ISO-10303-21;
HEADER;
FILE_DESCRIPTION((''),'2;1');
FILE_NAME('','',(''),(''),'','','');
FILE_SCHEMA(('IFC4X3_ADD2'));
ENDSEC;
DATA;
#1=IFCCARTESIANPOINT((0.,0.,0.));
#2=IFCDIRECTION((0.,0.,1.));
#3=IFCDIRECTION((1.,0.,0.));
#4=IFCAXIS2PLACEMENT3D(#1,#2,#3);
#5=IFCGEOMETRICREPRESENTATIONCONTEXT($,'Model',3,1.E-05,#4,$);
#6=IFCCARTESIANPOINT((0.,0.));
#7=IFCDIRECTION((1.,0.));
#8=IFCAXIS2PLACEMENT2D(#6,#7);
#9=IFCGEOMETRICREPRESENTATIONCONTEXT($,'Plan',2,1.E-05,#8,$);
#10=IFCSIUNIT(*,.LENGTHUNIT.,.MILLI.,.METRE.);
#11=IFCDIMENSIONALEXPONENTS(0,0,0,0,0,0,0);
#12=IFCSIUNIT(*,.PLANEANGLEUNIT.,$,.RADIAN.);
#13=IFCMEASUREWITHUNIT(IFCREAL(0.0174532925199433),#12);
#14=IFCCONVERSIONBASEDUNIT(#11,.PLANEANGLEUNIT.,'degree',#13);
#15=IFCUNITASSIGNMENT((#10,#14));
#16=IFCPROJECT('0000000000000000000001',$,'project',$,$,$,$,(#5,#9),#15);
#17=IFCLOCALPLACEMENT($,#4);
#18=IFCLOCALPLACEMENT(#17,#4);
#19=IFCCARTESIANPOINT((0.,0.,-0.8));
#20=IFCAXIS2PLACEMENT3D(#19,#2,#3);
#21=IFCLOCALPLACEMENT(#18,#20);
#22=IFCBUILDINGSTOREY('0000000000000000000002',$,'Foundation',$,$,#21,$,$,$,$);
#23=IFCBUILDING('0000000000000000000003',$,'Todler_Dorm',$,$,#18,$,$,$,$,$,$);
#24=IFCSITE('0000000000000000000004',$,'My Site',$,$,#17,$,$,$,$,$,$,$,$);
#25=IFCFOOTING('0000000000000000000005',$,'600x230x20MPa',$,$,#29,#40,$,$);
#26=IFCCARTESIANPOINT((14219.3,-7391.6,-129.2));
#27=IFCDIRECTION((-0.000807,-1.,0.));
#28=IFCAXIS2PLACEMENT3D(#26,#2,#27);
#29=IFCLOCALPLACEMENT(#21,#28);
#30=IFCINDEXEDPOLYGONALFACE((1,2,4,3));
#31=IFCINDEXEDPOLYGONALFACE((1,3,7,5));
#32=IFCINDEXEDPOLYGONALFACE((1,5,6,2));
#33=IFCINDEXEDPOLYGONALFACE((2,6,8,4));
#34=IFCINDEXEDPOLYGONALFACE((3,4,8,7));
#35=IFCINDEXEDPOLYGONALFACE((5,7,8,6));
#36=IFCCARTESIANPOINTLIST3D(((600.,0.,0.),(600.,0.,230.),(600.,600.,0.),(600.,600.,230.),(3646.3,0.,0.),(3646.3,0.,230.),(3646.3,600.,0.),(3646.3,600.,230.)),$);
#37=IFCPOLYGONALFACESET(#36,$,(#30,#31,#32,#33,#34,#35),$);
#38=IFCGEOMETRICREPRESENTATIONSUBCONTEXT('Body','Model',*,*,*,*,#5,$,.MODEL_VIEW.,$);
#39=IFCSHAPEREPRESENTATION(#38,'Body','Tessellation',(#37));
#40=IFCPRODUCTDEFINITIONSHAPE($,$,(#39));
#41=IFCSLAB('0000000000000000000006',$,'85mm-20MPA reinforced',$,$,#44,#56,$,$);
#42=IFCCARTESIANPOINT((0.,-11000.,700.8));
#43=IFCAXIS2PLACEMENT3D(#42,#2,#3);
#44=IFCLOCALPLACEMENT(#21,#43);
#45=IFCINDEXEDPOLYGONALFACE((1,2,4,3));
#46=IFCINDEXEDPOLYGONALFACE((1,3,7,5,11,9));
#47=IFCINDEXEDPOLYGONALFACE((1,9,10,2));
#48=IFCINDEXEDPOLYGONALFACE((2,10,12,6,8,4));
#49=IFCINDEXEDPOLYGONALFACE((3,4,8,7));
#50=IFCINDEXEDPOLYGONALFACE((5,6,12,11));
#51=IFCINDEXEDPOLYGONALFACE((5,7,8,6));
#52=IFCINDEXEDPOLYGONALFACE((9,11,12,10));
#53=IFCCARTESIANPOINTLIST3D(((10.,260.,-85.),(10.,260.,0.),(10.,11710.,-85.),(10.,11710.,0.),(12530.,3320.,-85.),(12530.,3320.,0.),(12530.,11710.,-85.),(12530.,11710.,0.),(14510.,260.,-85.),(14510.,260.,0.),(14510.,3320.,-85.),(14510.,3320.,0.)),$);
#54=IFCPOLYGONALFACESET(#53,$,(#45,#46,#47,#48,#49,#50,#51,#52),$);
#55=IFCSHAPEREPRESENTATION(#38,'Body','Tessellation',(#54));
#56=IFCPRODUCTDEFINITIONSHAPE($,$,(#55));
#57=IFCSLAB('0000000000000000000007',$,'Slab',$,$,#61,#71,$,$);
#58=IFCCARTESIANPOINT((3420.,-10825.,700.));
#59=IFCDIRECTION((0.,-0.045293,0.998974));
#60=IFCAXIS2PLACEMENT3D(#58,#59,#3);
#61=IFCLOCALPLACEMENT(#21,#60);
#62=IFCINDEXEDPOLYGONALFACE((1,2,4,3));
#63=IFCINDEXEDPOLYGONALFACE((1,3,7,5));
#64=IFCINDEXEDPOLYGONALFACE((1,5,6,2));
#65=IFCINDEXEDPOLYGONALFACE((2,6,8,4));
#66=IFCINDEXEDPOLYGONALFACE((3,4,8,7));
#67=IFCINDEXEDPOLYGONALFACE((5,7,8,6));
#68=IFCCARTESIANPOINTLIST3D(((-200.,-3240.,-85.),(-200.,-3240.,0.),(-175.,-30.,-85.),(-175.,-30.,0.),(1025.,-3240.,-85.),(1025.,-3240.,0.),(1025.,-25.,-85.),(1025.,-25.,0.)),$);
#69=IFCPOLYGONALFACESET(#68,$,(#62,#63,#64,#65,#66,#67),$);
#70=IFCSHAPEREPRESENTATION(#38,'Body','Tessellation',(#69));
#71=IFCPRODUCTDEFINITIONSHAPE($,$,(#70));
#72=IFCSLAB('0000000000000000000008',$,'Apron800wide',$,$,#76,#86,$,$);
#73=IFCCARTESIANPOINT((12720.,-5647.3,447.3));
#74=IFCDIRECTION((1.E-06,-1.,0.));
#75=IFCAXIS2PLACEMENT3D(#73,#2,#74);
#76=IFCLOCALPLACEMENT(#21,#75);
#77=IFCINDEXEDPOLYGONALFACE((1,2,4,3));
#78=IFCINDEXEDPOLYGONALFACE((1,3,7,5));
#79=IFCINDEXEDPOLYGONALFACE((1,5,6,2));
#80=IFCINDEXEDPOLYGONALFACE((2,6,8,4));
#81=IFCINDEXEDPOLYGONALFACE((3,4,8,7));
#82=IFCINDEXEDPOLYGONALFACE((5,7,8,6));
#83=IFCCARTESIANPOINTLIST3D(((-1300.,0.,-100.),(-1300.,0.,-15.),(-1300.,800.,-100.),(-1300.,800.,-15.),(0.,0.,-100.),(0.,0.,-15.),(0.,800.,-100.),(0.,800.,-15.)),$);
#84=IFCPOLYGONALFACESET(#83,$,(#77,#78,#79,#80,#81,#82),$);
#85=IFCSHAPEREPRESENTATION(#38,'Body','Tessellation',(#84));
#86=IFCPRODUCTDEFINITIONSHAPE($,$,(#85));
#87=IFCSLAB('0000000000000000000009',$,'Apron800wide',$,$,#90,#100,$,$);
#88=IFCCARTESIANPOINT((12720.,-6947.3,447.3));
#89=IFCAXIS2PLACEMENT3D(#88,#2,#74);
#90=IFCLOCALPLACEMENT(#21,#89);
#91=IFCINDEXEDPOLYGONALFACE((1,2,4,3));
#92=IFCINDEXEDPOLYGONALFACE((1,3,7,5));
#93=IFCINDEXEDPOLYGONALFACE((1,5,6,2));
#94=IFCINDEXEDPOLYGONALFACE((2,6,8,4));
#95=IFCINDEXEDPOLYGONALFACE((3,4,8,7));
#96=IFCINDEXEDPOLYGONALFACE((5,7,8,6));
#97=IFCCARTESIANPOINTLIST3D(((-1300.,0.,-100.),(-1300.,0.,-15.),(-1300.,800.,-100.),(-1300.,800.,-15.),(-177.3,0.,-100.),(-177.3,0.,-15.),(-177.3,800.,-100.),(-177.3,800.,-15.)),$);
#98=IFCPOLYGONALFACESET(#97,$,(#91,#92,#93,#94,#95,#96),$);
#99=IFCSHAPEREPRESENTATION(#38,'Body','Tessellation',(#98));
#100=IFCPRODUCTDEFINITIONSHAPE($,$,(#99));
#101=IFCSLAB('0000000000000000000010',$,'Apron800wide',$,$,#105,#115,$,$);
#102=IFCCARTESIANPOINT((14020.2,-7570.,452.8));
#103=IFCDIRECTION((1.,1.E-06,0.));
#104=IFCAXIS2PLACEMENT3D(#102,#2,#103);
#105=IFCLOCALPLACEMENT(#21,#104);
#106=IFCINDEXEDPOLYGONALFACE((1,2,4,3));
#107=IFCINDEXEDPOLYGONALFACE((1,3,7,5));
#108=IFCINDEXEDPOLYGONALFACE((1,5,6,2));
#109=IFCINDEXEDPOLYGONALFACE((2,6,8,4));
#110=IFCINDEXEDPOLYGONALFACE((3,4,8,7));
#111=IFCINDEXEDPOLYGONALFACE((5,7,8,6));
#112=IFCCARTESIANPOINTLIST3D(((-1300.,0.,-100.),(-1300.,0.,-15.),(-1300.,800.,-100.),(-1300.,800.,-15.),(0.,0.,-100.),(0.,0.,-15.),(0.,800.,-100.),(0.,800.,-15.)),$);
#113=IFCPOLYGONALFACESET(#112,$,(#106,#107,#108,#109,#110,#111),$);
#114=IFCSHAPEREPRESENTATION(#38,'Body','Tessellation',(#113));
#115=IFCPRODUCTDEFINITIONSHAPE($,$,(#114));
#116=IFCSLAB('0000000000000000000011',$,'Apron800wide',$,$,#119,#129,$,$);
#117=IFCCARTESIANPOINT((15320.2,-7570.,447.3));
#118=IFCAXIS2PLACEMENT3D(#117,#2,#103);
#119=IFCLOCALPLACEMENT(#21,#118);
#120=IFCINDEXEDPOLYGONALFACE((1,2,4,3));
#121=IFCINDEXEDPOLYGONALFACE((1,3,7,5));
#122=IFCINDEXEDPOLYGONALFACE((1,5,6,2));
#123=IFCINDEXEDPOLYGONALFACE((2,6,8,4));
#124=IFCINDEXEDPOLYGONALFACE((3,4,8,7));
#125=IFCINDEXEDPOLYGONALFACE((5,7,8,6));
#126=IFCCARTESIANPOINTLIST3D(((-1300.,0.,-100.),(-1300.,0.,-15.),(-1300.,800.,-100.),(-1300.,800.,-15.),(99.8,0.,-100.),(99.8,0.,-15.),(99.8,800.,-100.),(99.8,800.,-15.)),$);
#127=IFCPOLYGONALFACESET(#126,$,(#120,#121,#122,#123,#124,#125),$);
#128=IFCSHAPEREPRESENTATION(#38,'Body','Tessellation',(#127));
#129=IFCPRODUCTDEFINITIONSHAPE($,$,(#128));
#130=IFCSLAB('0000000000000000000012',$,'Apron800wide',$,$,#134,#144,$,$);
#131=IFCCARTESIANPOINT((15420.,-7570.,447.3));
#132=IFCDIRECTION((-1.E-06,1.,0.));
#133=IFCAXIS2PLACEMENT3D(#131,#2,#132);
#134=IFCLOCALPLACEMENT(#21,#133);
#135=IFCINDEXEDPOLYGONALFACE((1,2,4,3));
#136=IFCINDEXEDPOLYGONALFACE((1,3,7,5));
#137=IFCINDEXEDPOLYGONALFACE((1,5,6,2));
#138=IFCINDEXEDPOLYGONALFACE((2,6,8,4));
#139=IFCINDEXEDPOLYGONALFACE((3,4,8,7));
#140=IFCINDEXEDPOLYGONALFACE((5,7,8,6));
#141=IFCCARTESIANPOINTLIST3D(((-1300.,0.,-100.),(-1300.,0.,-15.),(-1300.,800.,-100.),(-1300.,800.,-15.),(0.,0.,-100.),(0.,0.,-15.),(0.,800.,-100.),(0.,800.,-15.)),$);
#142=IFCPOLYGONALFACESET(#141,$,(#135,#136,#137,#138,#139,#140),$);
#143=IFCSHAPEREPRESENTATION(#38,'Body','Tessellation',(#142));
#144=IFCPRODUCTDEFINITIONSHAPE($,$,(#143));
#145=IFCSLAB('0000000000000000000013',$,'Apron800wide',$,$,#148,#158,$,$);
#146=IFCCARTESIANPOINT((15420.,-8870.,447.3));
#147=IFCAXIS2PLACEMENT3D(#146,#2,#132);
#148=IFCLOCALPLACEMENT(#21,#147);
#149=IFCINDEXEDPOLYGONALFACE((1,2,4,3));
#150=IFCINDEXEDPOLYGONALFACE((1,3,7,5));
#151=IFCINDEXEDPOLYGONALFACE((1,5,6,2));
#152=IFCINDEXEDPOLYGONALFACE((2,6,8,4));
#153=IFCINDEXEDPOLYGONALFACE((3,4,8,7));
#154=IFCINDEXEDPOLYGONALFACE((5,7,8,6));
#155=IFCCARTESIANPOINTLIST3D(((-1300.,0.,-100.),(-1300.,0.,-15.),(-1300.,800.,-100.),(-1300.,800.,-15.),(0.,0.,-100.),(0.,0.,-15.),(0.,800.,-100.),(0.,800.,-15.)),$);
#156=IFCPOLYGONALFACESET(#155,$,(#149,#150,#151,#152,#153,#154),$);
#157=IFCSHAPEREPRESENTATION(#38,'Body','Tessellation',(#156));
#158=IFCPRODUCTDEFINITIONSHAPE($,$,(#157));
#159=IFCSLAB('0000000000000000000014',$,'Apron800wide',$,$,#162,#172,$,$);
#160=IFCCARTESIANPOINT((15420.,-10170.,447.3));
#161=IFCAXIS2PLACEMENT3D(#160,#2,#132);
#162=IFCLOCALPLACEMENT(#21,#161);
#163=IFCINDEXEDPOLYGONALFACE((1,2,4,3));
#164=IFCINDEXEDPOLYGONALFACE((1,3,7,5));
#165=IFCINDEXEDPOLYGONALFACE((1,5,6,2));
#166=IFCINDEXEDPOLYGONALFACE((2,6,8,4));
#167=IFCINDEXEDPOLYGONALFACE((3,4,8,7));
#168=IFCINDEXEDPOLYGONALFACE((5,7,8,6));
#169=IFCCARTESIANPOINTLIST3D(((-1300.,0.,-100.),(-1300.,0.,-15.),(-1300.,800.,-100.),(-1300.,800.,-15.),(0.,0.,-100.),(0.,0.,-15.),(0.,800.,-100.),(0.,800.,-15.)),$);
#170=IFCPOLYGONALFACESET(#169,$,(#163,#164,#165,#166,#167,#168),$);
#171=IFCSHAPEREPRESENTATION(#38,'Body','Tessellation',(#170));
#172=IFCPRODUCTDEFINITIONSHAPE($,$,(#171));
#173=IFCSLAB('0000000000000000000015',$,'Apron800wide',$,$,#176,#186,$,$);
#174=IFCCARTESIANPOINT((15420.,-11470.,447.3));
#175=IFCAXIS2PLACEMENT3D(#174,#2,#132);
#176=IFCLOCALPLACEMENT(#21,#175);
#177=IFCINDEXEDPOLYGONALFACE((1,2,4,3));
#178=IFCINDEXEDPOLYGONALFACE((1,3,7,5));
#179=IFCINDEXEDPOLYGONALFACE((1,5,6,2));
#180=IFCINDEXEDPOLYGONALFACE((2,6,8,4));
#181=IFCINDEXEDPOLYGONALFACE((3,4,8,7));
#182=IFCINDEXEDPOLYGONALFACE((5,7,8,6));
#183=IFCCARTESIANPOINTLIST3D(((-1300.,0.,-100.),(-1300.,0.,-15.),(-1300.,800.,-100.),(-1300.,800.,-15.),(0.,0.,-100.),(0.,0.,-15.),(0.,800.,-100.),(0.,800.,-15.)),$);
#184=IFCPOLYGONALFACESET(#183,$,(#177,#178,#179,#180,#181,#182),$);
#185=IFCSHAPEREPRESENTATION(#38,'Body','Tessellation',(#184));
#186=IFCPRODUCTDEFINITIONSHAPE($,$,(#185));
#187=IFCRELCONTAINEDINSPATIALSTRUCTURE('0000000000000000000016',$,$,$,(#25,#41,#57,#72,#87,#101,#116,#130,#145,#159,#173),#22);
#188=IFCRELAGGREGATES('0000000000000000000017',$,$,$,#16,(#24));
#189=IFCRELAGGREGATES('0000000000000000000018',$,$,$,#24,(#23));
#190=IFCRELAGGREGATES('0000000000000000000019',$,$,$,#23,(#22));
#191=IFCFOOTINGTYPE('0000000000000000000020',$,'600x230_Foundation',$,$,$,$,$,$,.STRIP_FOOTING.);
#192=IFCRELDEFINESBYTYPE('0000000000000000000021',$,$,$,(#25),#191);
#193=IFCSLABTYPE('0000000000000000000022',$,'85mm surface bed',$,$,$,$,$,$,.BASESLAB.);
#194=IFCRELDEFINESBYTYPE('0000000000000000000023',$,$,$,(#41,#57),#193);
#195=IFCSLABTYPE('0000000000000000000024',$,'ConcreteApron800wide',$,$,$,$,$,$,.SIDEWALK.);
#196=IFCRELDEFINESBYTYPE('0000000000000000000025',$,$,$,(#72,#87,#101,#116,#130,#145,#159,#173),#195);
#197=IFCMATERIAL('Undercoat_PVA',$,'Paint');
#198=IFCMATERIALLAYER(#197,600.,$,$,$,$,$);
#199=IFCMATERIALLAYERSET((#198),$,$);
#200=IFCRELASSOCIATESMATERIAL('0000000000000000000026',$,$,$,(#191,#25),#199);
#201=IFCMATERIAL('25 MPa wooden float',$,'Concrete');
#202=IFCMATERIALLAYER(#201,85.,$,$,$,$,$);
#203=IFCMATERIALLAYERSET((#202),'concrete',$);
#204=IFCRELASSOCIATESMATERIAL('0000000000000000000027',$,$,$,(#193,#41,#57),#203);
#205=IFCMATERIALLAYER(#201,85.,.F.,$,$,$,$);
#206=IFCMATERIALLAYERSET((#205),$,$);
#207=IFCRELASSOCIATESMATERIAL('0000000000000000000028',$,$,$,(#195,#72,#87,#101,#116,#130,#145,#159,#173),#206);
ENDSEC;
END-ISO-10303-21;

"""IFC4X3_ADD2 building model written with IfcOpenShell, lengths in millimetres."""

from ifc_helpers import new_model, entity, si_unit, converted_unit, frame, origin_with_axes, origin_2d_with_axis, place, context, subcontext, project, spatial, line, indexed_curve, outline, extrude, material, layer, layer_set, layer_usage, type_object, element, save


model = new_model("IFC4X3_ADD2")

# Units and contexts
model_context = context("Model", 3, precision=1e-05, world=origin_with_axes())
plan_context = context("Plan", 2, precision=1e-05, world=origin_2d_with_axis())
body_context = subcontext(model_context, "Body", "Model", "MODEL_VIEW")
ifc_project = project(units=[si_unit("LENGTHUNIT", "METRE", prefix="MILLI"), converted_unit("PLANEANGLEUNIT", "degree", entity("IfcReal", 0.0174532925199433), si_unit("PLANEANGLEUNIT", "RADIAN"), dimensions=[0, 0, 0, 0, 0, 0, 0])], contexts=[model_context, plan_context])

# Site, building, storey
site_placement = place(None, origin_with_axes())
site = spatial("IfcSite", under=ifc_project, at=site_placement, Name="My Site")
building_placement = place(site_placement, origin_with_axes())
building = spatial("IfcBuilding", under=site, at=building_placement, Name="Todler_Dorm")
storey_placement = place(building_placement, frame((0.0, 0.0, -0.8), z_axis=(0.0, 0.0, 1.0), x_axis=(1.0, 0.0, 0.0)))
storey = spatial("IfcBuildingStorey", under=building, at=storey_placement, Name="Foundation")

# Footing
ifc_material_1 = material(Name="Undercoat_PVA", Category="Paint")
ifc_layer_1 = layer(ifc_material_1, 600.0)
ifc_layer_set_1 = layer_set([ifc_layer_1])
footing_type = type_object("IfcFootingType", Name="600x230_Foundation", PredefinedType="STRIP_FOOTING", material=ifc_layer_set_1)
ifc_layer_usage_1 = layer_usage(ifc_layer_set_1, "AXIS2", "POSITIVE", 0.0)
footing_1_placement = place(storey_placement, frame((14219.3, -7391.6, -129.2), z_axis=(0.0, 0.0, 1.0), x_axis=(-0.000807, -1.0, 0.0)))
element("IfcFooting", 1, at=footing_1_placement, inside=storey, type_object=footing_type, material=ifc_layer_usage_1, Name="600x230x20MPa", context=body_context, shape_type="SweptSolid", body=[
    extrude(outline(indexed_curve([(600.0, 0.0), (600.0, 600.0), (3646.3, 600.0), (3646.3, 0.0)], segments=[line(1, 2, 3, 4, 1)])), origin_with_axes(), (0.0, 0.0, 1.0), 230.0),
])

# Slabs
ifc_material_2 = material(Name="25 MPa wooden float", Category="Concrete")
ifc_layer_2 = layer(ifc_material_2, 85.0)
ifc_layer_set_2 = layer_set([ifc_layer_2], Name="concrete")
ifc_layer_usage_2 = layer_usage(ifc_layer_set_2, "AXIS3", "POSITIVE", -85.0)
slab_type_1 = type_object("IfcSlabType", Name="85mm surface bed", PredefinedType="BASESLAB", material=ifc_layer_set_2)
slab_1_placement = place(storey_placement, frame((0.0, -11000.0, 700.8), z_axis=(0.0, 0.0, 1.0), x_axis=(1.0, 0.0, 0.0)))
element("IfcSlab", 2, at=slab_1_placement, inside=storey, type_object=slab_type_1, material=ifc_layer_usage_2, Name="85mm-20MPA reinforced", context=body_context, shape_type="SweptSolid", body=[
    extrude(outline(indexed_curve([(10.0, 260.0), (14510.0, 260.0), (14510.0, 3320.0), (12530.0, 3320.0), (12530.0, 11710.0), (10.0, 11710.0), (10.0, 260.0)])), frame((0.0, 0.0, -85.0), z_axis=(0.0, 0.0, 1.0), x_axis=(1.0, 0.0, 0.0)), (0.0, 0.0, 1.0), 85.0),
])
ifc_layer_usage_3 = layer_usage(ifc_layer_set_2, "AXIS3", "POSITIVE", -85.0)
slab_2_placement = place(storey_placement, frame((3420.0, -10825.0, 700.0), z_axis=(0.0, -0.045293, 0.998974), x_axis=(1.0, 0.0, 0.0)))
element("IfcSlab", 3, at=slab_2_placement, inside=storey, type_object=slab_type_1, material=ifc_layer_usage_3, Name="Slab", context=body_context, shape_type="SweptSolid", body=[
    extrude(outline(indexed_curve([(-175.0, -30.0), (-200.0, -3240.0), (1025.0, -3240.0), (1025.0, -25.0), (-175.0, -30.0)])), frame((0.0, 0.0, -85.0), z_axis=(0.0, 0.0, 1.0), x_axis=(1.0, 0.0, 0.0)), (0.0, 0.0, 1.0), 85.0),
])
ifc_layer_3 = layer(ifc_material_2, 85.0, ventilated=False)
ifc_layer_set_3 = layer_set([ifc_layer_3])
ifc_layer_usage_4 = layer_usage(ifc_layer_set_3, "AXIS3", "POSITIVE", -100.0)
slab_type_2 = type_object("IfcSlabType", Name="ConcreteApron800wide", PredefinedType="SIDEWALK", material=ifc_layer_set_3)
slab_3_placement = place(storey_placement, frame((12720.0, -5647.3, 447.3), z_axis=(0.0, 0.0, 1.0), x_axis=(0.000001, -1.0, 0.0)))
element("IfcSlab", 4, at=slab_3_placement, inside=storey, type_object=slab_type_2, material=ifc_layer_usage_4, Name="Apron800wide", context=body_context, shape_type="SweptSolid", body=[
    extrude(outline(indexed_curve([(0.0, 0.0), (0.0, 800.0), (-1300.0, 800.0), (-1300.0, 0.0), (0.0, 0.0)])), frame((0.0, 0.0, -100.0), z_axis=(0.0, 0.0, 1.0), x_axis=(1.0, 0.0, 0.0)), (0.0, 0.0, 1.0), 85.0),
])
ifc_layer_usage_5 = layer_usage(ifc_layer_set_3, "AXIS3", "POSITIVE", -100.0)
slab_4_placement = place(storey_placement, frame((12720.0, -6947.3, 447.3), z_axis=(0.0, 0.0, 1.0), x_axis=(0.000001, -1.0, 0.0)))
element("IfcSlab", 5, at=slab_4_placement, inside=storey, type_object=slab_type_2, material=ifc_layer_usage_5, Name="Apron800wide", context=body_context, shape_type="SweptSolid", body=[
    extrude(outline(indexed_curve([(-1300.0, 0.0), (-1300.0, 800.0), (-177.3, 800.0), (-177.3, 0.0), (-1300.0, 0.0)])), frame((0.0, 0.0, -100.0), z_axis=(0.0, 0.0, 1.0), x_axis=(1.0, 0.0, 0.0)), (0.0, 0.0, 1.0), 85.0),
])
ifc_layer_usage_6 = layer_usage(ifc_layer_set_3, "AXIS3", "POSITIVE", -100.0)
slab_5_placement = place(storey_placement, frame((14020.2, -7570.0, 452.8), z_axis=(0.0, 0.0, 1.0), x_axis=(1.0, 0.000001, 0.0)))
element("IfcSlab", 6, at=slab_5_placement, inside=storey, type_object=slab_type_2, material=ifc_layer_usage_6, Name="Apron800wide", context=body_context, shape_type="SweptSolid", body=[
    extrude(outline(indexed_curve([(0.0, 0.0), (0.0, 800.0), (-1300.0, 800.0), (-1300.0, 0.0), (0.0, 0.0)])), frame((0.0, 0.0, -100.0), z_axis=(0.0, 0.0, 1.0), x_axis=(1.0, 0.0, 0.0)), (0.0, 0.0, 1.0), 85.0),
])
ifc_layer_usage_7 = layer_usage(ifc_layer_set_3, "AXIS3", "POSITIVE", -100.0)
slab_6_placement = place(storey_placement, frame((15320.2, -7570.0, 447.3), z_axis=(0.0, 0.0, 1.0), x_axis=(1.0, 0.000001, 0.0)))
element("IfcSlab", 7, at=slab_6_placement, inside=storey, type_object=slab_type_2, material=ifc_layer_usage_7, Name="Apron800wide", context=body_context, shape_type="SweptSolid", body=[
    extrude(outline(indexed_curve([(-1300.0, 0.0), (-1300.0, 800.0), (99.8, 800.0), (99.8, 0.0), (-1300.0, 0.0)])), frame((0.0, 0.0, -100.0), z_axis=(0.0, 0.0, 1.0), x_axis=(1.0, 0.0, 0.0)), (0.0, 0.0, 1.0), 85.0),
])
ifc_layer_usage_8 = layer_usage(ifc_layer_set_3, "AXIS3", "POSITIVE", -100.0)
slab_7_placement = place(storey_placement, frame((15420.0, -7570.0, 447.3), z_axis=(0.0, 0.0, 1.0), x_axis=(-0.000001, 1.0, 0.0)))
element("IfcSlab", 8, at=slab_7_placement, inside=storey, type_object=slab_type_2, material=ifc_layer_usage_8, Name="Apron800wide", context=body_context, shape_type="SweptSolid", body=[
    extrude(outline(indexed_curve([(0.0, 0.0), (0.0, 800.0), (-1300.0, 800.0), (-1300.0, 0.0), (0.0, 0.0)])), frame((0.0, 0.0, -100.0), z_axis=(0.0, 0.0, 1.0), x_axis=(1.0, 0.0, 0.0)), (0.0, 0.0, 1.0), 85.0),
])
ifc_layer_usage_9 = layer_usage(ifc_layer_set_3, "AXIS3", "POSITIVE", -100.0)
slab_8_placement = place(storey_placement, frame((15420.0, -8870.0, 447.3), z_axis=(0.0, 0.0, 1.0), x_axis=(-0.000001, 1.0, 0.0)))
element("IfcSlab", 9, at=slab_8_placement, inside=storey, type_object=slab_type_2, material=ifc_layer_usage_9, Name="Apron800wide", context=body_context, shape_type="SweptSolid", body=[
    extrude(outline(indexed_curve([(0.0, 0.0), (0.0, 800.0), (-1300.0, 800.0), (-1300.0, 0.0), (0.0, 0.0)])), frame((0.0, 0.0, -100.0), z_axis=(0.0, 0.0, 1.0), x_axis=(1.0, 0.0, 0.0)), (0.0, 0.0, 1.0), 85.0),
])
ifc_layer_usage_10 = layer_usage(ifc_layer_set_3, "AXIS3", "POSITIVE", -100.0)
slab_9_placement = place(storey_placement, frame((15420.0, -10170.0, 447.3), z_axis=(0.0, 0.0, 1.0), x_axis=(-0.000001, 1.0, 0.0)))
element("IfcSlab", 10, at=slab_9_placement, inside=storey, type_object=slab_type_2, material=ifc_layer_usage_10, Name="Apron800wide", context=body_context, shape_type="SweptSolid", body=[
    extrude(outline(indexed_curve([(0.0, 0.0), (0.0, 800.0), (-1300.0, 800.0), (-1300.0, 0.0), (0.0, 0.0)])), frame((0.0, 0.0, -100.0), z_axis=(0.0, 0.0, 1.0), x_axis=(1.0, 0.0, 0.0)), (0.0, 0.0, 1.0), 85.0),
])
ifc_layer_usage_11 = layer_usage(ifc_layer_set_3, "AXIS3", "POSITIVE", -100.0)
slab_10_placement = place(storey_placement, frame((15420.0, -11470.0, 447.3), z_axis=(0.0, 0.0, 1.0), x_axis=(-0.000001, 1.0, 0.0)))
element("IfcSlab", 11, at=slab_10_placement, inside=storey, type_object=slab_type_2, material=ifc_layer_usage_11, Name="Apron800wide", context=body_context, shape_type="SweptSolid", body=[
    extrude(outline(indexed_curve([(0.0, 0.0), (0.0, 800.0), (-1300.0, 800.0), (-1300.0, 0.0), (0.0, 0.0)])), frame((0.0, 0.0, -100.0), z_axis=(0.0, 0.0, 1.0), x_axis=(1.0, 0.0, 0.0)), (0.0, 0.0, 1.0), 85.0),
])

save(model, "model.ifc")
